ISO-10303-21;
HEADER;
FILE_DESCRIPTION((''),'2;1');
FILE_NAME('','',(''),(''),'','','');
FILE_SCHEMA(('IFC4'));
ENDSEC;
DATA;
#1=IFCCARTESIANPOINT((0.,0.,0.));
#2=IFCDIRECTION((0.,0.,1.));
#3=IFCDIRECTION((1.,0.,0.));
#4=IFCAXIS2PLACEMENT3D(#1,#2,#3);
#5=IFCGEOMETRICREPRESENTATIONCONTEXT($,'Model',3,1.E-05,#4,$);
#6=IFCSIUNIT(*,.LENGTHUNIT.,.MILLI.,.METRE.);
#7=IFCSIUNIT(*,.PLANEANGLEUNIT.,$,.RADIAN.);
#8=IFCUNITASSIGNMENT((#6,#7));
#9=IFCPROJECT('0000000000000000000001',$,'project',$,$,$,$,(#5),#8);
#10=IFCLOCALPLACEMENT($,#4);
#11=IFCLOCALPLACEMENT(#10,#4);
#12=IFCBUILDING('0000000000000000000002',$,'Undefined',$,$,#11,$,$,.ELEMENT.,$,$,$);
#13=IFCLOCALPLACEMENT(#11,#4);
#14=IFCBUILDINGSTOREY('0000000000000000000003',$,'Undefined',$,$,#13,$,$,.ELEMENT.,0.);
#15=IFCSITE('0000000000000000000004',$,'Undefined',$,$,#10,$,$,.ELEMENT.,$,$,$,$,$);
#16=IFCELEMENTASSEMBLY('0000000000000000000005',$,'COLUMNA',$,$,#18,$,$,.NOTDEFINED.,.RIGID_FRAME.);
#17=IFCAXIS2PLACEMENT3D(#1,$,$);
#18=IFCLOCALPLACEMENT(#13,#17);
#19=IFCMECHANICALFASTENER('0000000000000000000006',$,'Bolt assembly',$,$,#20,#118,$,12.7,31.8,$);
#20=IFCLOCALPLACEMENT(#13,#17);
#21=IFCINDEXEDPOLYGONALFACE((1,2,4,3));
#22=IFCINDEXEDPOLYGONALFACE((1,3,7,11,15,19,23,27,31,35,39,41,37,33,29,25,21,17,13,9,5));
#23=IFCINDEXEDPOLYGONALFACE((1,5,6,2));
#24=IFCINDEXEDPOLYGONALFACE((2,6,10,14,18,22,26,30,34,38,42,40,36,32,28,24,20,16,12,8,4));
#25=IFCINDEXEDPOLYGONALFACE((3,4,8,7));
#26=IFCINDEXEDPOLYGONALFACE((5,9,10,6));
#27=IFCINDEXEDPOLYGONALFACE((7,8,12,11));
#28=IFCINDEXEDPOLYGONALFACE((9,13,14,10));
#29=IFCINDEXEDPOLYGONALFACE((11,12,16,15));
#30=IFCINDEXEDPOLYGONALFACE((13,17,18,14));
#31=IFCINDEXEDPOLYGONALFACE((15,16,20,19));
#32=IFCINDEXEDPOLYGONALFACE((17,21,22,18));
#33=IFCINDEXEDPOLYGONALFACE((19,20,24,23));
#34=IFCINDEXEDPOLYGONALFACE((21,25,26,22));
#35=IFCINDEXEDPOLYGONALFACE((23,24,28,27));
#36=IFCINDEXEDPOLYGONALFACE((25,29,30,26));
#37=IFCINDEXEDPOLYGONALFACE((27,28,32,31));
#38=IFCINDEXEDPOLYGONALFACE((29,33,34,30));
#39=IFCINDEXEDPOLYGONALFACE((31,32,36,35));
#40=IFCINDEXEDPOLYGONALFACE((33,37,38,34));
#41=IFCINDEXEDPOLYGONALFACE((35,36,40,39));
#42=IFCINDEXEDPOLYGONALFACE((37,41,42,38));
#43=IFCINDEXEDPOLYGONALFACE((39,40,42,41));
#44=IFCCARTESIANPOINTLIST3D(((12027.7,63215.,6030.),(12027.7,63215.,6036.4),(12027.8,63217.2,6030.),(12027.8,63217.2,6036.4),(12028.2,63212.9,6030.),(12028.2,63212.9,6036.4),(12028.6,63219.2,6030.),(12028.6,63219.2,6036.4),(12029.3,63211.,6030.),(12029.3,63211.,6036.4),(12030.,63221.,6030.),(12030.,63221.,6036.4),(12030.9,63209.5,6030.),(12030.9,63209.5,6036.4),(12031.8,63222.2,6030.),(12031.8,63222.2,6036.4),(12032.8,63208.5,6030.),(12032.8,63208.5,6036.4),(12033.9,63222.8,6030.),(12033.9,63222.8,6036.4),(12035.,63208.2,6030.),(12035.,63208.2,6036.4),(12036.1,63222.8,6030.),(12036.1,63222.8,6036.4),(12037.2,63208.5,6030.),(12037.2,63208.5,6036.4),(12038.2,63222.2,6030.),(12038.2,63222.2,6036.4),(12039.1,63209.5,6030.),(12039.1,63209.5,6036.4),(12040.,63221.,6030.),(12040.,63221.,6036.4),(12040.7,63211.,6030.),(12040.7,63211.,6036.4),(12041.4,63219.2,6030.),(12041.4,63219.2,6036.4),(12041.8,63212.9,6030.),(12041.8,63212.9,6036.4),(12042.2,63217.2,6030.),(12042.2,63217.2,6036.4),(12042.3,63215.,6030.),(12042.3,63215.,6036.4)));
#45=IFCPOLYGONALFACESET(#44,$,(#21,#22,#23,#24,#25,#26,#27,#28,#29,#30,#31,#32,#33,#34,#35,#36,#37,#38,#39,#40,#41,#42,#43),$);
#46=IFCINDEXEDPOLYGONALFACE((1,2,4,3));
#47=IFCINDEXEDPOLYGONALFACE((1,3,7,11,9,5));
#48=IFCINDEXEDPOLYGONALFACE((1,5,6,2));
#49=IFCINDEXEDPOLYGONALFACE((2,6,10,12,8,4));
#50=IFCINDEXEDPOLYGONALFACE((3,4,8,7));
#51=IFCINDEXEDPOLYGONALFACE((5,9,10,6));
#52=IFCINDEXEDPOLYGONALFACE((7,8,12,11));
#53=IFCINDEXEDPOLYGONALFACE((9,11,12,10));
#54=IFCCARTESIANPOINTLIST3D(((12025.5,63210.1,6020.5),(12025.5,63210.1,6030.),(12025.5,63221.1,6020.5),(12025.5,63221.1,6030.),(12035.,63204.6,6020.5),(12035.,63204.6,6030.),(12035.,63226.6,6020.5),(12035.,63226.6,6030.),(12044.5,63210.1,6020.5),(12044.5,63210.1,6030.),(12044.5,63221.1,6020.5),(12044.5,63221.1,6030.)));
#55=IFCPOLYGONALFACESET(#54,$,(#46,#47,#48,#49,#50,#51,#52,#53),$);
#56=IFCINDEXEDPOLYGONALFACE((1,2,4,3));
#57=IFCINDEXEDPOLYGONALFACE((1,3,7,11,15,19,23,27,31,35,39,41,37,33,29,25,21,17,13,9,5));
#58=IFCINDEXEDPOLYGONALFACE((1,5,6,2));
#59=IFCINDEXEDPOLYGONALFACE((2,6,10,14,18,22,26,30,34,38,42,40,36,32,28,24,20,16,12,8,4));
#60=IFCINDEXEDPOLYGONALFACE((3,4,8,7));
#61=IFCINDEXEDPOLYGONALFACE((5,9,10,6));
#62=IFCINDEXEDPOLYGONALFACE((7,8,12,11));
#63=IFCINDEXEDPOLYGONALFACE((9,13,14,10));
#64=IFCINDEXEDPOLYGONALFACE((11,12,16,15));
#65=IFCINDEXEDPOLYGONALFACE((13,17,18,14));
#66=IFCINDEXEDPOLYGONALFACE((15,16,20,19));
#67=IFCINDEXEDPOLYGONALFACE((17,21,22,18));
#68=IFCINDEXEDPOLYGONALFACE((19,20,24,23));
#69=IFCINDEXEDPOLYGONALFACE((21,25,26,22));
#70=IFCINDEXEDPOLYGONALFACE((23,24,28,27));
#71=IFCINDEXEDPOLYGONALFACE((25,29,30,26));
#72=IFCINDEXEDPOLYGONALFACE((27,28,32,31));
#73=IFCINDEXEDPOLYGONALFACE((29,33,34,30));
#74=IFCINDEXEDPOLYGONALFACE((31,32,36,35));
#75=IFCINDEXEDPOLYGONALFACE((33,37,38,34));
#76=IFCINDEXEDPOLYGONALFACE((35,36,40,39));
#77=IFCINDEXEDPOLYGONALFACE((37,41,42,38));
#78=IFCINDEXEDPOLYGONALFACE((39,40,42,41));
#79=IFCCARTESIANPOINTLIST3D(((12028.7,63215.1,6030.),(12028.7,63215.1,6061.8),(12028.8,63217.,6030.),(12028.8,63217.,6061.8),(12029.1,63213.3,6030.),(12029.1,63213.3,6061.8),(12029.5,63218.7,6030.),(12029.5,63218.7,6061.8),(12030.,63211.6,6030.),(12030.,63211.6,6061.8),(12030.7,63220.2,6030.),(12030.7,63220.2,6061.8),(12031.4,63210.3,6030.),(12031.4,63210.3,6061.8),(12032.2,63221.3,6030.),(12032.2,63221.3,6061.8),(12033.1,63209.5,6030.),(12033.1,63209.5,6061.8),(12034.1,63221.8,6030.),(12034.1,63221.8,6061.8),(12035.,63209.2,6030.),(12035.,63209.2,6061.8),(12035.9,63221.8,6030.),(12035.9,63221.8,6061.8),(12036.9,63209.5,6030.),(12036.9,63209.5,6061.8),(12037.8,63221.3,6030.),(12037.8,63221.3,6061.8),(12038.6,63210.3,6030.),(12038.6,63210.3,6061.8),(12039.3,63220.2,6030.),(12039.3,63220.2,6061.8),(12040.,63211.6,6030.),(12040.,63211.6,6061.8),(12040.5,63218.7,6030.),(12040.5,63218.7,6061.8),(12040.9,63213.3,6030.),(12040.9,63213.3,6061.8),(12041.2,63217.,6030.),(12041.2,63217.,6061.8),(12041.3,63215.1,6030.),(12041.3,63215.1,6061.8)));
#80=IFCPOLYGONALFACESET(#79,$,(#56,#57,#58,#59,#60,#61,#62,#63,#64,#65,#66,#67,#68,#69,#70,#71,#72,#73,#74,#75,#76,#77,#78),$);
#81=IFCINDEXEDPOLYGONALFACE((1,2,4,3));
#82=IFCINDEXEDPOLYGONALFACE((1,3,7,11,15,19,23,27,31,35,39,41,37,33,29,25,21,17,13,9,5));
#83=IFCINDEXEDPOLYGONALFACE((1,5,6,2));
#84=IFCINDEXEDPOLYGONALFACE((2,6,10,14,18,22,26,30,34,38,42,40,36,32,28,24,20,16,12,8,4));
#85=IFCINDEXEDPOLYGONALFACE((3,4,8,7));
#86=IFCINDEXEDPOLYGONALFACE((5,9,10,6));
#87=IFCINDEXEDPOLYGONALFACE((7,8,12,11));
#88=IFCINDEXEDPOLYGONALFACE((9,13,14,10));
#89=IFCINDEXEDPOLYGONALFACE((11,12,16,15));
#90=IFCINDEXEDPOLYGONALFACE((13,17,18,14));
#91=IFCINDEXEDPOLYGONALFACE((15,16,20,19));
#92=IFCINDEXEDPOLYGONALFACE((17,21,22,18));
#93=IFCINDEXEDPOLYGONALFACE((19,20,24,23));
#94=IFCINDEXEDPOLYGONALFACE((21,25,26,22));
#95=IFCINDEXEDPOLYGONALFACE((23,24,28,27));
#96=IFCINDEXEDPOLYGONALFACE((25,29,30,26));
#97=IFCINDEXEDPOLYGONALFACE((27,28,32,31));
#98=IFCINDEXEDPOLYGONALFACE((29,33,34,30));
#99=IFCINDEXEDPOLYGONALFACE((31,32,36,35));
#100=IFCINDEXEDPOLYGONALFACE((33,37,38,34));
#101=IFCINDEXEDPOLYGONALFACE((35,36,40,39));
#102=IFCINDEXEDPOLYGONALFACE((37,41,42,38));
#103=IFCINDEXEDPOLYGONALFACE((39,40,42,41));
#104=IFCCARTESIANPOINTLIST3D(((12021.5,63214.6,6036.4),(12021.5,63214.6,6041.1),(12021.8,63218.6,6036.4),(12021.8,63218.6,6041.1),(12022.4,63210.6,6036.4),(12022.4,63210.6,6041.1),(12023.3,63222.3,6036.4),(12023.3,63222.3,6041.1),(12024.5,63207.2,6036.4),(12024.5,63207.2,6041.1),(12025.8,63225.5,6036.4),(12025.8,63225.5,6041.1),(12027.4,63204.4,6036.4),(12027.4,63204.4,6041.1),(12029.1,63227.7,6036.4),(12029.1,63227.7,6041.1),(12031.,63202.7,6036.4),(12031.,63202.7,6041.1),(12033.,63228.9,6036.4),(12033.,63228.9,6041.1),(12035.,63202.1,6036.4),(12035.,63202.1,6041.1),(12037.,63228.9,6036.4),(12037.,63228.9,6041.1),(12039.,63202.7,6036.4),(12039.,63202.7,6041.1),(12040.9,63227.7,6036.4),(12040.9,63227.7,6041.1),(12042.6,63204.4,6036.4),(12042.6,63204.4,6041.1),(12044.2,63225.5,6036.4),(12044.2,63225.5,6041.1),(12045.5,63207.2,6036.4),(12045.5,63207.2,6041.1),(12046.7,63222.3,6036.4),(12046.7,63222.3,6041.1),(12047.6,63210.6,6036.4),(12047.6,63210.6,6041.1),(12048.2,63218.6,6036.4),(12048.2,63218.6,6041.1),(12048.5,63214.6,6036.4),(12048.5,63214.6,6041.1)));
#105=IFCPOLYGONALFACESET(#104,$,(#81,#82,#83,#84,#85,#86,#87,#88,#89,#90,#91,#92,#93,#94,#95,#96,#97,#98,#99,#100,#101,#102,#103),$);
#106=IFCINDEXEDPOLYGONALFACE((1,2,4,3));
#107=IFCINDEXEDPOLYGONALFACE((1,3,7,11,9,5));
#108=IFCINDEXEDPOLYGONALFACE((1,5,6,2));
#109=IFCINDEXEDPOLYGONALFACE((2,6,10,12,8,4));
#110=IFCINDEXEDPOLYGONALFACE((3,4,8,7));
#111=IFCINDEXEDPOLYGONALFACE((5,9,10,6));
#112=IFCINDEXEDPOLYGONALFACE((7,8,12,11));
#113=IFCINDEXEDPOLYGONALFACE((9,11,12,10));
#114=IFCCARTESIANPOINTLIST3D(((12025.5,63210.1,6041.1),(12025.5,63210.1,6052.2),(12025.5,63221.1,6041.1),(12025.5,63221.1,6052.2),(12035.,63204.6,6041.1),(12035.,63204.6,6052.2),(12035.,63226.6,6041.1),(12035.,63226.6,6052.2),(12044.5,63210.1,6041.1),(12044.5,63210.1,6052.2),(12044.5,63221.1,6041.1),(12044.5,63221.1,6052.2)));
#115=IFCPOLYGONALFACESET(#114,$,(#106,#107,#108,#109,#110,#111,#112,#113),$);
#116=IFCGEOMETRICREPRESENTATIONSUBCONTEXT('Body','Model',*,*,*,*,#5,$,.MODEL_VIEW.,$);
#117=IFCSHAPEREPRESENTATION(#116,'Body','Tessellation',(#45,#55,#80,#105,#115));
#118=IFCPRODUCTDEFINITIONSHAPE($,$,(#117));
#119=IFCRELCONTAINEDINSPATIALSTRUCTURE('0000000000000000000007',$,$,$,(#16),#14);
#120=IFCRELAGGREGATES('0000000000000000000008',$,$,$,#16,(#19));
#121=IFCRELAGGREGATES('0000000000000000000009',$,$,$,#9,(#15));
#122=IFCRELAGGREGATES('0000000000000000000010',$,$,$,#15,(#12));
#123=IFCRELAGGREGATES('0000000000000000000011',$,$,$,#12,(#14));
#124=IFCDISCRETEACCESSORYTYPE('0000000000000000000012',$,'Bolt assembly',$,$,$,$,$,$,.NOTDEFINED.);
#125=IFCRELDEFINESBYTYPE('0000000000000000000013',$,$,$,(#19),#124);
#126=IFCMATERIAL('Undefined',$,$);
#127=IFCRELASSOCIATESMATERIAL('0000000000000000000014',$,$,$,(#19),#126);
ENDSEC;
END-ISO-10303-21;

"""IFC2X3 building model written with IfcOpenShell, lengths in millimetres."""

from ifc_helpers import new_model, si_unit, frame, origin_with_axes, origin_2d_with_axis, place, context, subcontext, project, spatial, polyline, circle, outline, extrude, source, transform, mapped, material, type_object, element, aggregate, save


model = new_model("IFC2X3")

# Units and contexts
model_context = context("Model", 3, precision=1e-05, world=origin_with_axes())
body_context = subcontext(model_context, "Body", "Model", "MODEL_VIEW")
ifc_project = project(units=[si_unit("LENGTHUNIT", "METRE", prefix="MILLI"), si_unit("PLANEANGLEUNIT", "RADIAN")], contexts=[model_context])

# Site, building, storey
site_placement = place(None, origin_with_axes())
site = spatial("IfcSite", under=ifc_project, at=site_placement, Name="Undefined", CompositionType="ELEMENT")
building_placement = place(site_placement, origin_with_axes())
building = spatial("IfcBuilding", under=site, at=building_placement, Name="Undefined", CompositionType="ELEMENT")
storey_placement = place(building_placement, origin_with_axes())
storey = spatial("IfcBuildingStorey", under=building, at=storey_placement, Name="Undefined", CompositionType="ELEMENT", Elevation=0.0)

# Element assembly
assembly_1_placement = place(storey_placement, origin_with_axes())
assembly_1 = element("IfcElementAssembly", 1, at=assembly_1_placement, inside=storey, Name="COLUMNA", AssemblyPlace="NOTDEFINED", PredefinedType="RIGID_FRAME")

# Shared definitions
ifc_material_1 = material(Name="Undefined")
discrete_accessory_type_1 = type_object("IfcDiscreteAccessoryType", Name="Bolt assembly")

# Mechanical fastener
shared_shape_1 = source(origin_with_axes(), body_context, "Body", "SweptSolid", [
    extrude(circle(Radius=7.3, at=origin_2d_with_axis()), frame((0.0, 2.5, 0.0), z_axis=(0.0, 1.0, 0.0), x_axis=(1.0, 0.0, 0.0)), (0.0, 0.0, 1.0), 6.5),
    extrude(outline(polyline([(11.0, 0.0), (5.5, 9.5), (-5.5, 9.5), (-11.0, 0.0), (-5.5, -9.5), (5.5, -9.5), (11.0, 0.0)])), frame((0.0, -7.0, 0.0), z_axis=(0.0, 1.0, 0.0), x_axis=(1.0, 0.0, 0.0)), (0.0, 0.0, 1.0), 9.5),
    extrude(circle(Radius=6.3, at=origin_2d_with_axis()), frame((0.0, 2.5, 0.0), z_axis=(0.0, 1.0, 0.0), x_axis=(1.0, 0.0, 0.0)), (0.0, 0.0, 1.0), 31.8),
    extrude(circle(Radius=13.5, at=origin_2d_with_axis()), frame((0.0, 8.9, 0.0), z_axis=(0.0, 1.0, 0.0), x_axis=(1.0, 0.0, 0.0)), (0.0, 0.0, 1.0), 4.8),
    extrude(outline(polyline([(11.0, 0.0), (5.5, 9.5), (-5.5, 9.5), (-11.0, 0.0), (-5.5, -9.5), (5.5, -9.5), (11.0, 0.0)])), frame((0.0, 13.6, 0.0), z_axis=(0.0, 1.0, 0.0), x_axis=(1.0, 0.0, 0.0)), (0.0, 0.0, 1.0), 11.1),
])
mechanical_fastener_1_placement = place(assembly_1_placement, frame((12035.0, 63275.6, 6027.5), z_axis=(-1.0, 0.0, 0.0), x_axis=(0.0, -1.0, 0.0)))
mechanical_fastener_1 = element("IfcMechanicalFastener", 2, at=mechanical_fastener_1_placement, type_object=discrete_accessory_type_1, material=ifc_material_1, Name="Bolt assembly", NominalDiameter=12.7, NominalLength=31.8, context=body_context, shape_type="MappedRepresentation", body=[
    mapped(shared_shape_1, transform((60.0, 0.0, 0.0))),
])
aggregate(assembly_1, [mechanical_fastener_1])

save(model, "model.ifc")
